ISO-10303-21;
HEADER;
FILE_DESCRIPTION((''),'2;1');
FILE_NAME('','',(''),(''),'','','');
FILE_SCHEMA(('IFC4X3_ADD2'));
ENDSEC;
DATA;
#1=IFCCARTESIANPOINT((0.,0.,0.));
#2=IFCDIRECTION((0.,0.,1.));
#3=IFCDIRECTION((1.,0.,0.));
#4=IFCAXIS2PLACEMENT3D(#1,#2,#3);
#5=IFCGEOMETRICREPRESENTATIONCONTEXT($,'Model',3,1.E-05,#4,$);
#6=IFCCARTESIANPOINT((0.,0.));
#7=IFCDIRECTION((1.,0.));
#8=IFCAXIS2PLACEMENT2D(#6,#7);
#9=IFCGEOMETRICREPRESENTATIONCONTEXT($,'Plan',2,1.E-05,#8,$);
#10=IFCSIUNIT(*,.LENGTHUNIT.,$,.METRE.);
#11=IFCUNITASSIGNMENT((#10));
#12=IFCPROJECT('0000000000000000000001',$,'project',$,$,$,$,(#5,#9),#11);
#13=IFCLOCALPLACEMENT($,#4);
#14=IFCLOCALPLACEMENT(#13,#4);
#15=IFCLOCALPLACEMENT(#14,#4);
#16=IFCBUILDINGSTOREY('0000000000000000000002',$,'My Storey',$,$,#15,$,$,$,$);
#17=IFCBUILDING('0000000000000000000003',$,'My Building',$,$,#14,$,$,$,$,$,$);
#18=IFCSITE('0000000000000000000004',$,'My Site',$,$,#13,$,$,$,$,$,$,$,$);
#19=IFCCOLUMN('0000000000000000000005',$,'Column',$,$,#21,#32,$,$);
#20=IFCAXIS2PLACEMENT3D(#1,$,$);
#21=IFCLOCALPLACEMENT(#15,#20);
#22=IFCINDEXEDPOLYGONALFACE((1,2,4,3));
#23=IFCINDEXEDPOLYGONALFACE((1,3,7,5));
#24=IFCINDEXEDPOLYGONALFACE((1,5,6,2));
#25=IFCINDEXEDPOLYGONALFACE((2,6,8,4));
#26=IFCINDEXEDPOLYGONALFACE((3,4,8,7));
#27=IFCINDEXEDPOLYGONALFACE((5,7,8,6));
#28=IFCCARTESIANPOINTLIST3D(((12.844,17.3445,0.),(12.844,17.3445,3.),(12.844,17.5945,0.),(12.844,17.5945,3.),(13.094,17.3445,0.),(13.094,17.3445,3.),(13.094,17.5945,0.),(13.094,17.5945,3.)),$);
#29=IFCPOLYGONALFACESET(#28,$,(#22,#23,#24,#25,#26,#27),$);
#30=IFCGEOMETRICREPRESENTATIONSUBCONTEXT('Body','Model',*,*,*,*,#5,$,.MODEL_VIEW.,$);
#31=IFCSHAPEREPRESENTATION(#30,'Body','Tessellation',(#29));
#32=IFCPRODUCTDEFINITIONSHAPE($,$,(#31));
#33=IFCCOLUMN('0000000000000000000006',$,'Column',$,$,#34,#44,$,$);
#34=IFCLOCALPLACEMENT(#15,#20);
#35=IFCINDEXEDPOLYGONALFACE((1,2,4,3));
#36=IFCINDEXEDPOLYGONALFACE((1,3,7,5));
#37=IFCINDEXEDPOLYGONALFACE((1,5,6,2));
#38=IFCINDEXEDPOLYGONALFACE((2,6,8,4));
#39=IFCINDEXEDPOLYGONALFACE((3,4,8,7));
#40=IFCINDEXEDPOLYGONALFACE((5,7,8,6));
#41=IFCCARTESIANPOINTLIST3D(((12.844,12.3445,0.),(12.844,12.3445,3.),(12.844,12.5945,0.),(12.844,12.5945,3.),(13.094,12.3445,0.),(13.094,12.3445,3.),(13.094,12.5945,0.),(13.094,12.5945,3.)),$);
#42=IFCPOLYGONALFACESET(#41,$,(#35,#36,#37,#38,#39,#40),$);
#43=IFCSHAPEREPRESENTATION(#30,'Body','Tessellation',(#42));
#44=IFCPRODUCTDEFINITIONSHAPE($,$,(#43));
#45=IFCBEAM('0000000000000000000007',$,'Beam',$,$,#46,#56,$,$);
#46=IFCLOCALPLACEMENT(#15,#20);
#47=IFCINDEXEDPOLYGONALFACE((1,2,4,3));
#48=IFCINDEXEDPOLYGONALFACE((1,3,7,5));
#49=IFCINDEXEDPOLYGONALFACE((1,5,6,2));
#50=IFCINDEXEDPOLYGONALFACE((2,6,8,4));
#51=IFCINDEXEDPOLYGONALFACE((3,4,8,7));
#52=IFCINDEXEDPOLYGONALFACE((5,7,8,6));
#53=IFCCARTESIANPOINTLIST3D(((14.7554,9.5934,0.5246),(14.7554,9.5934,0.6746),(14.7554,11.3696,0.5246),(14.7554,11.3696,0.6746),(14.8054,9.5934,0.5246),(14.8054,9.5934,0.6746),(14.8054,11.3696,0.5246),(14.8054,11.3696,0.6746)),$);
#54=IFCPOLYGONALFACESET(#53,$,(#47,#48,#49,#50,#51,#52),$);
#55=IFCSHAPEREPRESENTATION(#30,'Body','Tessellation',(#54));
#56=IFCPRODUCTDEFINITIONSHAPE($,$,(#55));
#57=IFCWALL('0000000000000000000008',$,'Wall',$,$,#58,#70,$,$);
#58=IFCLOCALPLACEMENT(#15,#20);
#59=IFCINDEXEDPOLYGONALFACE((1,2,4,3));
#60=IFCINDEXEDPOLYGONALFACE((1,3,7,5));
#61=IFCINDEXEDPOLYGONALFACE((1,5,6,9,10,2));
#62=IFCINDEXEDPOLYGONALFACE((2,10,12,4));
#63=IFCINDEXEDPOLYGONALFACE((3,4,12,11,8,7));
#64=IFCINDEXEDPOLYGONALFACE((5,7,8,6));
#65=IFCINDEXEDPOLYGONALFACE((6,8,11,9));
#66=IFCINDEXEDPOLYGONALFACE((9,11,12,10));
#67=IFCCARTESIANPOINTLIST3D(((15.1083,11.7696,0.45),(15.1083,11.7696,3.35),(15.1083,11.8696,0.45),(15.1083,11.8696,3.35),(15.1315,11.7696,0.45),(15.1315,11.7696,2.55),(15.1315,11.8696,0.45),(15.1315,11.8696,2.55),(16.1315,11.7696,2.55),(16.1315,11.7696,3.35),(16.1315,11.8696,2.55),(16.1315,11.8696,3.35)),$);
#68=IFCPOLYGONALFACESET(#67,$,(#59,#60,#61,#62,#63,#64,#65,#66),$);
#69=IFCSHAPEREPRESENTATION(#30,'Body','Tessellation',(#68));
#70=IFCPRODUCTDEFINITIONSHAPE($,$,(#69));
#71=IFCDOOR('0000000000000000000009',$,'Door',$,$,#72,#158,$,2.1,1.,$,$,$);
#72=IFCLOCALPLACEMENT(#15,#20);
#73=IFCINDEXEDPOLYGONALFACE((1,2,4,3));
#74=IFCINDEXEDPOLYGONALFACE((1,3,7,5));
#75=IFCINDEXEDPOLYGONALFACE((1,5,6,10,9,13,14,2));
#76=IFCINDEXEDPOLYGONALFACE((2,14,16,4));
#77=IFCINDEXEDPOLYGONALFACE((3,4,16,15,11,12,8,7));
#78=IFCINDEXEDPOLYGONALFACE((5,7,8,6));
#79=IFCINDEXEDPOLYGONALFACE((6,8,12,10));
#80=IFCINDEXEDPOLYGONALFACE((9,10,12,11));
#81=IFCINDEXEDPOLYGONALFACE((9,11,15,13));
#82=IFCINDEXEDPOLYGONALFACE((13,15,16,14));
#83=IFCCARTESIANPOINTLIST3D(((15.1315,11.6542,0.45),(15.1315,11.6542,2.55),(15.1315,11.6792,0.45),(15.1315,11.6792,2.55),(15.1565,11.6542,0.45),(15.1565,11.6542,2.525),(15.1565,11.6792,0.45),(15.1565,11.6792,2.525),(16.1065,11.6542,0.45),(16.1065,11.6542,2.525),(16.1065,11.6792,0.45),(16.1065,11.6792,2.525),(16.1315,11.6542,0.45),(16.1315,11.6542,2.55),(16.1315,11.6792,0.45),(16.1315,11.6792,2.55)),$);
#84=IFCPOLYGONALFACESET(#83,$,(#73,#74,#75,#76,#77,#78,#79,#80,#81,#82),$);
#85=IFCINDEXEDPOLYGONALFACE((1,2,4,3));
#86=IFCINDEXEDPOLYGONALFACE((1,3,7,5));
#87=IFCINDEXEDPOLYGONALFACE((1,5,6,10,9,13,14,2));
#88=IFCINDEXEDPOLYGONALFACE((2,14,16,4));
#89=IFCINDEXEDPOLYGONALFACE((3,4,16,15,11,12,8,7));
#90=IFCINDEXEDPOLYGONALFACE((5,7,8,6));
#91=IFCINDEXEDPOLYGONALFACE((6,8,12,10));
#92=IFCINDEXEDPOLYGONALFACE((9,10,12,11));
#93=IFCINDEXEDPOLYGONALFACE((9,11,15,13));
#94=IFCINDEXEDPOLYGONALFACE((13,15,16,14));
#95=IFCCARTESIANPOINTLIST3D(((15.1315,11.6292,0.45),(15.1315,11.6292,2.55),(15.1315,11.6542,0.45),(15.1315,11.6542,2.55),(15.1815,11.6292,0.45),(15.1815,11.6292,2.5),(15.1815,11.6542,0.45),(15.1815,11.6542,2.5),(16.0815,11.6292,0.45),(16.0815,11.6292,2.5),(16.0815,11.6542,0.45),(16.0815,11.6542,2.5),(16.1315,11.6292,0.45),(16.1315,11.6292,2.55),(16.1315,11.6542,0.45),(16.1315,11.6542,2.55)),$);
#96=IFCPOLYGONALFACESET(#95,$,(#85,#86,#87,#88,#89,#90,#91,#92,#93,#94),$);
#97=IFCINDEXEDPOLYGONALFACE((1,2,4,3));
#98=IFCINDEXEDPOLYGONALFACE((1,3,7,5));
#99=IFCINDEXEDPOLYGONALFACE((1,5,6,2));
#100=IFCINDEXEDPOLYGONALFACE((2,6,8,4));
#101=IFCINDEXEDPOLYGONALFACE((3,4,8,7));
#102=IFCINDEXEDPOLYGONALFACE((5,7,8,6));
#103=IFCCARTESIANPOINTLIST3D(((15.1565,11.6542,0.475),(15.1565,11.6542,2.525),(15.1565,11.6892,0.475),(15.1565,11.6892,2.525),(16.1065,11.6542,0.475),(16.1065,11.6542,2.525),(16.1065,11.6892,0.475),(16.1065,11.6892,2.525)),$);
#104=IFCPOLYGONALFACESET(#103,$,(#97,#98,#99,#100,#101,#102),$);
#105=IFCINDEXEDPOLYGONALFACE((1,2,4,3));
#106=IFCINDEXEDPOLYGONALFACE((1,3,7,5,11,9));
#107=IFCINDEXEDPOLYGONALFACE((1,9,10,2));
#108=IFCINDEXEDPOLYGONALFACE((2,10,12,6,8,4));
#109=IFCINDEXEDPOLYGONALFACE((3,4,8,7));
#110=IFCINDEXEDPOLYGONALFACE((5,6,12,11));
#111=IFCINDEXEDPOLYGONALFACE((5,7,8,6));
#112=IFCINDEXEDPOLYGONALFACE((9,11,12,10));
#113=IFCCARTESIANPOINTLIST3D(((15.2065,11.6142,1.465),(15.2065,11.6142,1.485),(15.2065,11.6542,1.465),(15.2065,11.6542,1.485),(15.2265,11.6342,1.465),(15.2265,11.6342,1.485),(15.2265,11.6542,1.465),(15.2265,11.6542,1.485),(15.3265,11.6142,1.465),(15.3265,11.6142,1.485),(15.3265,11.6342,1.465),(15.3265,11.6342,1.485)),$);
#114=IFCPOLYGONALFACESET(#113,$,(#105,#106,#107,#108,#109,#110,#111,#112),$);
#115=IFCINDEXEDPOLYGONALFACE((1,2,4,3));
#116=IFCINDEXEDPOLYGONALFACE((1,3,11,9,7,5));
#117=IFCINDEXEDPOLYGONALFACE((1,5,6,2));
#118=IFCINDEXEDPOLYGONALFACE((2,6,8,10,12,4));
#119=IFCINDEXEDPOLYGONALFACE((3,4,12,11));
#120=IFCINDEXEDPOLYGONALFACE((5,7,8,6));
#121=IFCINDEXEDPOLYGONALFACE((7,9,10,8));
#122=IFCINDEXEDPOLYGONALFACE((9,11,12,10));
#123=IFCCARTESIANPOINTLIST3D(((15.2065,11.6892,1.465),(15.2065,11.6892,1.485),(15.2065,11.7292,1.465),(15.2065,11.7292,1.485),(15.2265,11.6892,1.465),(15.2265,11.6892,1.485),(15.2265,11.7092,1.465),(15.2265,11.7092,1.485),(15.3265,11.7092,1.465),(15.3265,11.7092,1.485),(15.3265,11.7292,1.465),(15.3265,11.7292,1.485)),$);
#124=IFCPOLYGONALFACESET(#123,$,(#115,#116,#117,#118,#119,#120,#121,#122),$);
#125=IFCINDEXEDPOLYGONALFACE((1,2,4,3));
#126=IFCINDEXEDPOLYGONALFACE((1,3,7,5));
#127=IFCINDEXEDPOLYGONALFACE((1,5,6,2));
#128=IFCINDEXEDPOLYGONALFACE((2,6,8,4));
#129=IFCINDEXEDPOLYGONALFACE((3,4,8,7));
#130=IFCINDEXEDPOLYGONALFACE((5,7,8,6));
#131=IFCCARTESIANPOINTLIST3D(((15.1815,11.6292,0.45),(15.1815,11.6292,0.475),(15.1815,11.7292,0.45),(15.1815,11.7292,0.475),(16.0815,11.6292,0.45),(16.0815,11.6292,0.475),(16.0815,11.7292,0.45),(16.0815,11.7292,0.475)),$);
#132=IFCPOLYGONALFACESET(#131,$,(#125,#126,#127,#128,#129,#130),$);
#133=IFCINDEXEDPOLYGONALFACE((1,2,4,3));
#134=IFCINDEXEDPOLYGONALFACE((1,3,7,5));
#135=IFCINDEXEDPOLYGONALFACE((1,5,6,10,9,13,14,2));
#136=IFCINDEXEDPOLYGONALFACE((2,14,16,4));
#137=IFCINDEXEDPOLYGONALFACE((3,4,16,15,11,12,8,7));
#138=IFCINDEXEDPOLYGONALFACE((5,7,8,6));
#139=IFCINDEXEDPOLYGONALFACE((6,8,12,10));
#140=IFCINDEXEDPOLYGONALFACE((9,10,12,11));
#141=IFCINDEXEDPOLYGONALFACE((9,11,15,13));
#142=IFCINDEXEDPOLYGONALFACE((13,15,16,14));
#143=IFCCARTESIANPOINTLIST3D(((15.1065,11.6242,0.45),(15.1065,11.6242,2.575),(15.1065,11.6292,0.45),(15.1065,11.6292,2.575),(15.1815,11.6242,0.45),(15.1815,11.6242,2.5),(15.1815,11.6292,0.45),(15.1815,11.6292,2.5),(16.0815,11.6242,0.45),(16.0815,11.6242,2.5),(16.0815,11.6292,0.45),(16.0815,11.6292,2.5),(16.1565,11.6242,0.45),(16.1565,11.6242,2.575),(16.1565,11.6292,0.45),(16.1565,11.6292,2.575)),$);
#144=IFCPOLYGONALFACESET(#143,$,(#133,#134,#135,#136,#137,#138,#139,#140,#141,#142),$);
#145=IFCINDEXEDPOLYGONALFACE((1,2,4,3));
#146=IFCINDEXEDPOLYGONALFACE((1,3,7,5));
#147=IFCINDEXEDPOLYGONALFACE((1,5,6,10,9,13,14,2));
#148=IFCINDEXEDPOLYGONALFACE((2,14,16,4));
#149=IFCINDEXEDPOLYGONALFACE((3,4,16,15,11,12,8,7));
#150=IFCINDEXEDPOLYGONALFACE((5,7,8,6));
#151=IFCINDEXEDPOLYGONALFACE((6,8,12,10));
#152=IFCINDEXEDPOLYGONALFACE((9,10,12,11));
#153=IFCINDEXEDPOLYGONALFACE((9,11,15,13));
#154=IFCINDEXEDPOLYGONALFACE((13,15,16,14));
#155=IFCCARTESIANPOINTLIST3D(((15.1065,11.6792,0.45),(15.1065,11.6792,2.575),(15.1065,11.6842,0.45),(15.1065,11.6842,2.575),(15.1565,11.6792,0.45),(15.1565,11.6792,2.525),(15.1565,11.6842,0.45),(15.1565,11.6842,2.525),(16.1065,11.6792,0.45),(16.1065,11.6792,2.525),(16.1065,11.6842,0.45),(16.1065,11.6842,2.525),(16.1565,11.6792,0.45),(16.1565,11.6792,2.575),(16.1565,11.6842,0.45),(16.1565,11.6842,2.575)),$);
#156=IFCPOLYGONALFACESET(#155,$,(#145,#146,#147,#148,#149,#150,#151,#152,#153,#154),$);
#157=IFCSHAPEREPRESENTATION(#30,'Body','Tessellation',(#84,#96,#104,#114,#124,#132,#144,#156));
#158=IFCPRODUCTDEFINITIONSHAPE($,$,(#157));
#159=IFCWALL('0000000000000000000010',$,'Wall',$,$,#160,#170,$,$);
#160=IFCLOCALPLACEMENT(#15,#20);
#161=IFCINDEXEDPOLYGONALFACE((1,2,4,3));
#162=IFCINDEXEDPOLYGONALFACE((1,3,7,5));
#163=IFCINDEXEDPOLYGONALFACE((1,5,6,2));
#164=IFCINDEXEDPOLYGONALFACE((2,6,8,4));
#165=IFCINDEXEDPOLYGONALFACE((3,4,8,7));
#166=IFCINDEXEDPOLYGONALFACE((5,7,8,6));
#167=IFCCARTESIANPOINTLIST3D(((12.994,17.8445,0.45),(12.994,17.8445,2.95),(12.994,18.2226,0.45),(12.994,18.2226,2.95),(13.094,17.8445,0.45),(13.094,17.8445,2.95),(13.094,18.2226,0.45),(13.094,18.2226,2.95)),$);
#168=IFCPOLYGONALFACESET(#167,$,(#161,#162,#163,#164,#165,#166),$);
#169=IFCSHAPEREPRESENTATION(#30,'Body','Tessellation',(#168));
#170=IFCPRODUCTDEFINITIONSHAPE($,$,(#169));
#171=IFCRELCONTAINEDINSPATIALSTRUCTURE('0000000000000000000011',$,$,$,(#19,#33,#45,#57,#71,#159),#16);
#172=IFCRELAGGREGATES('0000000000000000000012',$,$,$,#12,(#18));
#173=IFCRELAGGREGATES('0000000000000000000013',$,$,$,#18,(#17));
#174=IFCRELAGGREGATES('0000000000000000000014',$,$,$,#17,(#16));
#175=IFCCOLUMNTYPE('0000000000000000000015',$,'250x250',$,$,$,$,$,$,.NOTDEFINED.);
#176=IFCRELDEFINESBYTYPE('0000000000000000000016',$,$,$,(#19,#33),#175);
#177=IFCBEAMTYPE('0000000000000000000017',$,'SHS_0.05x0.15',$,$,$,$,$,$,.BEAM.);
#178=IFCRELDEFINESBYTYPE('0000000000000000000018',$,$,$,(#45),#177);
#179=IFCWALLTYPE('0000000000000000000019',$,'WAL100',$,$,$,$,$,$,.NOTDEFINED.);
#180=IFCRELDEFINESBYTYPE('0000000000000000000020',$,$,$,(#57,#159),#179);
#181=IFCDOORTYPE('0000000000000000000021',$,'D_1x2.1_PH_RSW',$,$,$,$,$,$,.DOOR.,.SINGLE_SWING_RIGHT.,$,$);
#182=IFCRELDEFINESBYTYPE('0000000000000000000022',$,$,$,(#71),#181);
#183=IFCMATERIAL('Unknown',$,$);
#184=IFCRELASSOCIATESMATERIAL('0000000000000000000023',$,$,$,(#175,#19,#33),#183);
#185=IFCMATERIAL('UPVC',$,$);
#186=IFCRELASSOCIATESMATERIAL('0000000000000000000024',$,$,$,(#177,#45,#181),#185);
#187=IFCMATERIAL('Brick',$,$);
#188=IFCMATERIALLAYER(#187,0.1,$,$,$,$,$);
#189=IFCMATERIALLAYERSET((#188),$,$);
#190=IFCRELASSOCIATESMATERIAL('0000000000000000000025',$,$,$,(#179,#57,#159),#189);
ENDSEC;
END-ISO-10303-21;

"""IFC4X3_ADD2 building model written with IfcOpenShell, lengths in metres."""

from ifc_helpers import new_model, entity, si_unit, frame, origin_with_axes, origin_2d_with_axis, place, context, subcontext, project, spatial, line, indexed_curve, rectangle, outline, extrude, shape, source, transform, mapped, material, layer, layer_set, layer_usage, material_profile, profile_set, profile_usage, type_object, type_shapes, element, fill, save


model = new_model("IFC4X3_ADD2")

# Units and contexts
model_context = context("Model", 3, precision=1e-05, world=origin_with_axes())
plan_context = context("Plan", 2, precision=1e-05, world=origin_2d_with_axis())
body_context_1 = subcontext(model_context, "Body", "Model", "MODEL_VIEW")
body_context_2 = subcontext(plan_context, "Body", "Plan", "PLAN_VIEW")
ifc_project = project(units=[si_unit("LENGTHUNIT", "METRE")], contexts=[model_context, plan_context])

# Site, building, storey
site_placement = place(None, origin_with_axes())
site = spatial("IfcSite", under=ifc_project, at=site_placement, Name="My Site")
building_placement = place(site_placement, origin_with_axes())
building = spatial("IfcBuilding", under=site, at=building_placement, Name="My Building")
storey_placement = place(building_placement, origin_with_axes())
storey = spatial("IfcBuildingStorey", under=building, at=storey_placement, Name="My Storey")

# Columns
ifc_material_1 = material(Name="Unknown")
ifc_material_profile_1 = material_profile(ifc_material_1, rectangle(XDim=0.25, YDim=0.25))
ifc_profile_set_1 = profile_set([ifc_material_profile_1])
ifc_profile_usage_1 = profile_usage(ifc_profile_set_1, cardinal=5)
column_type = type_object("IfcColumnType", Name="250x250", PredefinedType="NOTDEFINED", material=ifc_profile_set_1)
column_1_placement = place(storey_placement, frame((12.969, 17.4695, 0.0), z_axis=(0.0, 0.0, 1.0), x_axis=(1.0, 0.0, 0.0)))
element("IfcColumn", 1, at=column_1_placement, inside=storey, type_object=column_type, material=ifc_profile_usage_1, Name="Column", context=body_context_1, shape_type="SweptSolid", body=[
    extrude(rectangle(XDim=0.25, YDim=0.25), origin_with_axes(), (0.0, 0.0, 1.0), 3.0),
])
ifc_profile_usage_2 = profile_usage(ifc_profile_set_1, cardinal=5)
column_2_placement = place(storey_placement, frame((12.969, 12.4695, 0.0), z_axis=(0.0, 0.0, 1.0), x_axis=(1.0, 0.0, 0.0)))
element("IfcColumn", 2, at=column_2_placement, inside=storey, type_object=column_type, material=ifc_profile_usage_2, Name="Column", context=body_context_1, shape_type="SweptSolid", body=[
    extrude(rectangle(XDim=0.25, YDim=0.25), origin_with_axes(), (0.0, 0.0, 1.0), 3.0),
])

# Beam
ifc_material_2 = material(Name="UPVC")
ifc_material_profile_2 = material_profile(ifc_material_2, outline(indexed_curve([(-0.025, 0.075), (0.025, 0.075), (0.025, -0.075), (-0.025, -0.075), (-0.025, 0.075)])))
ifc_profile_set_2 = profile_set([ifc_material_profile_2])
ifc_profile_usage_3 = profile_usage(ifc_profile_set_2, cardinal=5)
beam_type = type_object("IfcBeamType", Name="SHS_0.05x0.15", PredefinedType="BEAM", material=ifc_profile_set_2)
beam_placement = place(storey_placement, frame((14.7804, 9.5934, 0.5996), z_axis=(0.0, 1.0, 0.0), x_axis=(-1.0, 0.0, 0.0)))
element("IfcBeam", 3, at=beam_placement, inside=storey, type_object=beam_type, material=ifc_profile_usage_3, Name="Beam", context=body_context_1, shape_type="SweptSolid", body=[
    extrude(outline(indexed_curve([(-0.025, 0.075), (0.025, 0.075), (0.025, -0.075), (-0.025, -0.075), (-0.025, 0.075)])), origin_with_axes(), (0.0, 0.0, 1.0), 1.7762),
])

# Wall, opening, door
ifc_material_3 = material(Name="Brick")
ifc_layer_1 = layer(ifc_material_3, 0.1)
ifc_layer_set_1 = layer_set([ifc_layer_1])
ifc_layer_usage_1 = layer_usage(ifc_layer_set_1, "AXIS2", "NEGATIVE", 0.0)
wall_type_1 = type_object("IfcWallType", Name="WAL100", PredefinedType="NOTDEFINED", material=ifc_layer_set_1)
wall_1_placement = place(storey_placement, frame((15.1083, 11.8696, 0.45), z_axis=(0.0, 0.0, 1.0), x_axis=(1.0, 0.000005, 0.0)))
wall_1 = element("IfcWall", 4, at=wall_1_placement, inside=storey, type_object=wall_type_1, material=ifc_layer_usage_1, Name="Wall", context=body_context_1, shape_type="SweptSolid", body=[
    extrude(outline(indexed_curve([(0.0, -0.1), (0.0, 0.0), (1.0231, 0.0), (1.0231, -0.1)], segments=[line(1, 2, 3, 4, 1)])), origin_with_axes(), (0.0, 0.0, 1.0), 2.9),
])
shared_shape_1 = source(origin_with_axes(), body_context_1, "Body", "SweptSolid", [
    extrude(outline(indexed_curve([(0.0, 0.0), (1.0, 0.0), (1.0, 2.1), (0.0, 2.1)], segments=[line(1, 2, 3, 4, 1)])), frame((0.0, -0.6, 0.0), z_axis=(0.0, -1.0, 0.0), x_axis=(1.0, 0.0, 0.0)), (0.0, 0.0, -1.0), 1.2),
])
opening_1_placement = place(wall_1_placement, frame((0.0231, -0.2403, 0.0), z_axis=(0.0, 0.0, 1.0), x_axis=(1.0, 0.0, 0.0)))
opening_1 = element("IfcOpeningElement", 5, at=opening_1_placement, cuts=wall_1, PredefinedType="OPENING", context=body_context_1, shape_type="MappedRepresentation", body=[
    mapped(shared_shape_1, transform((0.0, 0.0, 0.0), x_axis=(1.0, 0.0, 0.0), y_axis=(0.0, 1.0, 0.0), z_axis=(0.0, 0.0, 1.0), scale=1.0)),
])
door_type = type_object("IfcDoorType", Name="D_1x2.1_PH_RSW", OperationType="SINGLE_SWING_RIGHT", PredefinedType="DOOR", material=ifc_material_2)
shared_shape_2 = source(origin_with_axes(), body_context_1, "Body", "SweptSolid", [
    extrude(outline(indexed_curve([(0.0, 0.0), (0.0, 2.1), (1.0, 2.1), (1.0, 0.0), (0.975, 0.0), (0.975, 2.075), (0.025, 2.075), (0.025, 0.0)], segments=[line(1, 2, 3, 4, 5, 6, 7, 8, 1)])), frame((0.0, 0.025, 0.0), z_axis=(0.0, -1.0, 0.0), x_axis=(1.0, 0.0, 0.0)), (0.0, 0.0, -1.0), 0.025),
    extrude(outline(indexed_curve([(0.0, 0.0), (0.0, 2.1), (1.0, 2.1), (1.0, 0.0), (0.95, 0.0), (0.95, 2.05), (0.05, 2.05), (0.05, 0.0)], segments=[line(1, 2, 3, 4, 5, 6, 7, 8, 1)])), frame((0.0, 0.0, 0.0), z_axis=(0.0, -1.0, 0.0), x_axis=(1.0, 0.0, 0.0)), (0.0, 0.0, -1.0), 0.025),
    extrude(outline(indexed_curve([(0.0, 0.0), (0.95, 0.0), (0.95, 0.035), (0.0, 0.035)], segments=[line(1, 2, 3, 4, 1)])), frame((0.025, 0.025, 0.025), z_axis=(0.0, 0.0, 1.0), x_axis=(1.0, 0.0, 0.0)), (0.0, 0.0, 1.0), 2.05),
    extrude(outline(indexed_curve([(0.0, 0.0), (0.0, -0.04), (0.12, -0.04), (0.12, -0.02), (0.02, -0.02), (0.02, 0.0)], segments=[line(1, 2, 3, 4, 5, 6, 1)])), frame((0.075, 0.025, 1.015), z_axis=(0.0, 0.0, 1.0), x_axis=(1.0, 0.0, 0.0)), (0.0, 0.0, 1.0), 0.02),
    extrude(outline(indexed_curve([(0.0, 0.0), (0.0, 0.04), (0.12, 0.04), (0.12, 0.02), (0.02, 0.02), (0.02, 0.0)], segments=[line(1, 2, 3, 4, 5, 6, 1)])), frame((0.075, 0.06, 1.015), z_axis=(0.0, 0.0, 1.0), x_axis=(1.0, 0.0, 0.0)), (0.0, 0.0, 1.0), 0.02),
    extrude(outline(indexed_curve([(0.0, 0.0), (0.9, 0.0), (0.9, 0.1), (0.0, 0.1)], segments=[line(1, 2, 3, 4, 1)])), frame((0.05, 0.0, 0.0), z_axis=(0.0, 0.0, 1.0), x_axis=(1.0, 0.0, 0.0)), (0.0, 0.0, 1.0), 0.025),
    extrude(outline(indexed_curve([(0.0, 0.0), (0.0, 2.125), (1.05, 2.125), (1.05, 0.0), (0.975, 0.0), (0.975, 2.05), (0.075, 2.05), (0.075, 0.0)], segments=[line(1, 2, 3, 4, 5, 6, 7, 8, 1)])), frame((-0.025, -0.005, 0.0), z_axis=(0.0, -1.0, 0.0), x_axis=(1.0, 0.0, 0.0)), (0.0, 0.0, -1.0), 0.005),
    extrude(outline(indexed_curve([(0.0, 0.0), (0.0, 2.125), (1.05, 2.125), (1.05, 0.0), (1.0, 0.0), (1.0, 2.075), (0.05, 2.075), (0.05, 0.0)], segments=[line(1, 2, 3, 4, 5, 6, 7, 8, 1)])), frame((-0.025, 0.05, 0.0), z_axis=(0.0, -1.0, 0.0), x_axis=(1.0, 0.0, 0.0)), (0.0, 0.0, -1.0), 0.005),
])
shared_shape_3 = source(origin_with_axes(), body_context_2, "Body", "Curve2D", [
    entity("IfcIndexedPolyCurve", entity("IfcCartesianPointList2D", [[0.0, 0.0], [0.0, 0.05], [0.025, 0.05], [0.025, 0.025], [0.05, 0.025], [0.05, 0.0]]), [entity("IfcLineIndex", [1, 2, 3, 4, 5, 6, 1])]),
    entity("IfcIndexedPolyCurve", entity("IfcCartesianPointList2D", [[1.0, 0.0], [1.0, 0.05], [0.975, 0.05], [0.975, 0.025], [0.95, 0.025], [0.95, 0.0]]), [entity("IfcLineIndex", [1, 2, 3, 4, 5, 6, 1])]),
    entity("IfcTrimmedCurve", entity("IfcEllipse", entity("IfcAxis2Placement2D", entity("IfcCartesianPoint", [0.94, 0.05]), entity("IfcDirection", [1.0, 0.0])), 0.915, 0.95), [entity("IfcCartesianPoint", [0.94, 1.0])], [entity("IfcCartesianPoint", [0.025, 0.05])], True, "CARTESIAN"),
    entity("IfcIndexedPolyCurve", entity("IfcCartesianPointList2D", [[0.975, 0.05], [0.94, 0.05], [0.94, 1.0], [0.975, 1.0]]), [entity("IfcLineIndex", [1, 2, 3, 4, 1])]),
])
type_shapes(door_type, [shared_shape_2, shared_shape_3])
door_placement = place(opening_1_placement, frame((0.0, 0.0, 0.0), z_axis=(0.0, 0.0, 1.0), x_axis=(1.0, 0.0, 0.0)))
door = element("IfcDoor", 6, at=door_placement, inside=storey, type_object=door_type, Name="Door", OverallHeight=2.1, OverallWidth=1.0, shapes=[
    shape(body_context_1, "Body", "MappedRepresentation", [mapped(shared_shape_2, transform((0.0, 0.0, 0.0), x_axis=(1.0, 0.0, 0.0), y_axis=(0.0, 1.0, 0.0), z_axis=(0.0, 0.0, 1.0), scale=1.0))]),
    shape(body_context_2, "Body", "MappedRepresentation", [mapped(shared_shape_3, transform((0.0, 0.0, 0.0), x_axis=(1.0, 0.0, 0.0), y_axis=(0.0, 1.0, 0.0), z_axis=(0.0, 0.0, 1.0), scale=1.0))]),
])
fill(opening_1, door)

# Wall
ifc_layer_usage_2 = layer_usage(ifc_layer_set_1, "AXIS2", "POSITIVE", 0.0)
wall_2_placement = place(storey_placement, frame((13.094, 17.8445, 0.45), z_axis=(0.0, 0.0, 1.0), x_axis=(-0.000005, 1.0, 0.0)))
element("IfcWall", 7, at=wall_2_placement, inside=storey, type_object=wall_type_1, material=ifc_layer_usage_2, Name="Wall", context=body_context_1, shape_type="SweptSolid", body=[
    extrude(outline(indexed_curve([(0.0, 0.0), (0.0, 0.1), (0.3781, 0.1), (0.3781, 0.0)], segments=[line(1, 2, 3, 4, 1)])), origin_with_axes(), (0.0, 0.0, 1.0), 2.5),
])

save(model, "model.ifc")
